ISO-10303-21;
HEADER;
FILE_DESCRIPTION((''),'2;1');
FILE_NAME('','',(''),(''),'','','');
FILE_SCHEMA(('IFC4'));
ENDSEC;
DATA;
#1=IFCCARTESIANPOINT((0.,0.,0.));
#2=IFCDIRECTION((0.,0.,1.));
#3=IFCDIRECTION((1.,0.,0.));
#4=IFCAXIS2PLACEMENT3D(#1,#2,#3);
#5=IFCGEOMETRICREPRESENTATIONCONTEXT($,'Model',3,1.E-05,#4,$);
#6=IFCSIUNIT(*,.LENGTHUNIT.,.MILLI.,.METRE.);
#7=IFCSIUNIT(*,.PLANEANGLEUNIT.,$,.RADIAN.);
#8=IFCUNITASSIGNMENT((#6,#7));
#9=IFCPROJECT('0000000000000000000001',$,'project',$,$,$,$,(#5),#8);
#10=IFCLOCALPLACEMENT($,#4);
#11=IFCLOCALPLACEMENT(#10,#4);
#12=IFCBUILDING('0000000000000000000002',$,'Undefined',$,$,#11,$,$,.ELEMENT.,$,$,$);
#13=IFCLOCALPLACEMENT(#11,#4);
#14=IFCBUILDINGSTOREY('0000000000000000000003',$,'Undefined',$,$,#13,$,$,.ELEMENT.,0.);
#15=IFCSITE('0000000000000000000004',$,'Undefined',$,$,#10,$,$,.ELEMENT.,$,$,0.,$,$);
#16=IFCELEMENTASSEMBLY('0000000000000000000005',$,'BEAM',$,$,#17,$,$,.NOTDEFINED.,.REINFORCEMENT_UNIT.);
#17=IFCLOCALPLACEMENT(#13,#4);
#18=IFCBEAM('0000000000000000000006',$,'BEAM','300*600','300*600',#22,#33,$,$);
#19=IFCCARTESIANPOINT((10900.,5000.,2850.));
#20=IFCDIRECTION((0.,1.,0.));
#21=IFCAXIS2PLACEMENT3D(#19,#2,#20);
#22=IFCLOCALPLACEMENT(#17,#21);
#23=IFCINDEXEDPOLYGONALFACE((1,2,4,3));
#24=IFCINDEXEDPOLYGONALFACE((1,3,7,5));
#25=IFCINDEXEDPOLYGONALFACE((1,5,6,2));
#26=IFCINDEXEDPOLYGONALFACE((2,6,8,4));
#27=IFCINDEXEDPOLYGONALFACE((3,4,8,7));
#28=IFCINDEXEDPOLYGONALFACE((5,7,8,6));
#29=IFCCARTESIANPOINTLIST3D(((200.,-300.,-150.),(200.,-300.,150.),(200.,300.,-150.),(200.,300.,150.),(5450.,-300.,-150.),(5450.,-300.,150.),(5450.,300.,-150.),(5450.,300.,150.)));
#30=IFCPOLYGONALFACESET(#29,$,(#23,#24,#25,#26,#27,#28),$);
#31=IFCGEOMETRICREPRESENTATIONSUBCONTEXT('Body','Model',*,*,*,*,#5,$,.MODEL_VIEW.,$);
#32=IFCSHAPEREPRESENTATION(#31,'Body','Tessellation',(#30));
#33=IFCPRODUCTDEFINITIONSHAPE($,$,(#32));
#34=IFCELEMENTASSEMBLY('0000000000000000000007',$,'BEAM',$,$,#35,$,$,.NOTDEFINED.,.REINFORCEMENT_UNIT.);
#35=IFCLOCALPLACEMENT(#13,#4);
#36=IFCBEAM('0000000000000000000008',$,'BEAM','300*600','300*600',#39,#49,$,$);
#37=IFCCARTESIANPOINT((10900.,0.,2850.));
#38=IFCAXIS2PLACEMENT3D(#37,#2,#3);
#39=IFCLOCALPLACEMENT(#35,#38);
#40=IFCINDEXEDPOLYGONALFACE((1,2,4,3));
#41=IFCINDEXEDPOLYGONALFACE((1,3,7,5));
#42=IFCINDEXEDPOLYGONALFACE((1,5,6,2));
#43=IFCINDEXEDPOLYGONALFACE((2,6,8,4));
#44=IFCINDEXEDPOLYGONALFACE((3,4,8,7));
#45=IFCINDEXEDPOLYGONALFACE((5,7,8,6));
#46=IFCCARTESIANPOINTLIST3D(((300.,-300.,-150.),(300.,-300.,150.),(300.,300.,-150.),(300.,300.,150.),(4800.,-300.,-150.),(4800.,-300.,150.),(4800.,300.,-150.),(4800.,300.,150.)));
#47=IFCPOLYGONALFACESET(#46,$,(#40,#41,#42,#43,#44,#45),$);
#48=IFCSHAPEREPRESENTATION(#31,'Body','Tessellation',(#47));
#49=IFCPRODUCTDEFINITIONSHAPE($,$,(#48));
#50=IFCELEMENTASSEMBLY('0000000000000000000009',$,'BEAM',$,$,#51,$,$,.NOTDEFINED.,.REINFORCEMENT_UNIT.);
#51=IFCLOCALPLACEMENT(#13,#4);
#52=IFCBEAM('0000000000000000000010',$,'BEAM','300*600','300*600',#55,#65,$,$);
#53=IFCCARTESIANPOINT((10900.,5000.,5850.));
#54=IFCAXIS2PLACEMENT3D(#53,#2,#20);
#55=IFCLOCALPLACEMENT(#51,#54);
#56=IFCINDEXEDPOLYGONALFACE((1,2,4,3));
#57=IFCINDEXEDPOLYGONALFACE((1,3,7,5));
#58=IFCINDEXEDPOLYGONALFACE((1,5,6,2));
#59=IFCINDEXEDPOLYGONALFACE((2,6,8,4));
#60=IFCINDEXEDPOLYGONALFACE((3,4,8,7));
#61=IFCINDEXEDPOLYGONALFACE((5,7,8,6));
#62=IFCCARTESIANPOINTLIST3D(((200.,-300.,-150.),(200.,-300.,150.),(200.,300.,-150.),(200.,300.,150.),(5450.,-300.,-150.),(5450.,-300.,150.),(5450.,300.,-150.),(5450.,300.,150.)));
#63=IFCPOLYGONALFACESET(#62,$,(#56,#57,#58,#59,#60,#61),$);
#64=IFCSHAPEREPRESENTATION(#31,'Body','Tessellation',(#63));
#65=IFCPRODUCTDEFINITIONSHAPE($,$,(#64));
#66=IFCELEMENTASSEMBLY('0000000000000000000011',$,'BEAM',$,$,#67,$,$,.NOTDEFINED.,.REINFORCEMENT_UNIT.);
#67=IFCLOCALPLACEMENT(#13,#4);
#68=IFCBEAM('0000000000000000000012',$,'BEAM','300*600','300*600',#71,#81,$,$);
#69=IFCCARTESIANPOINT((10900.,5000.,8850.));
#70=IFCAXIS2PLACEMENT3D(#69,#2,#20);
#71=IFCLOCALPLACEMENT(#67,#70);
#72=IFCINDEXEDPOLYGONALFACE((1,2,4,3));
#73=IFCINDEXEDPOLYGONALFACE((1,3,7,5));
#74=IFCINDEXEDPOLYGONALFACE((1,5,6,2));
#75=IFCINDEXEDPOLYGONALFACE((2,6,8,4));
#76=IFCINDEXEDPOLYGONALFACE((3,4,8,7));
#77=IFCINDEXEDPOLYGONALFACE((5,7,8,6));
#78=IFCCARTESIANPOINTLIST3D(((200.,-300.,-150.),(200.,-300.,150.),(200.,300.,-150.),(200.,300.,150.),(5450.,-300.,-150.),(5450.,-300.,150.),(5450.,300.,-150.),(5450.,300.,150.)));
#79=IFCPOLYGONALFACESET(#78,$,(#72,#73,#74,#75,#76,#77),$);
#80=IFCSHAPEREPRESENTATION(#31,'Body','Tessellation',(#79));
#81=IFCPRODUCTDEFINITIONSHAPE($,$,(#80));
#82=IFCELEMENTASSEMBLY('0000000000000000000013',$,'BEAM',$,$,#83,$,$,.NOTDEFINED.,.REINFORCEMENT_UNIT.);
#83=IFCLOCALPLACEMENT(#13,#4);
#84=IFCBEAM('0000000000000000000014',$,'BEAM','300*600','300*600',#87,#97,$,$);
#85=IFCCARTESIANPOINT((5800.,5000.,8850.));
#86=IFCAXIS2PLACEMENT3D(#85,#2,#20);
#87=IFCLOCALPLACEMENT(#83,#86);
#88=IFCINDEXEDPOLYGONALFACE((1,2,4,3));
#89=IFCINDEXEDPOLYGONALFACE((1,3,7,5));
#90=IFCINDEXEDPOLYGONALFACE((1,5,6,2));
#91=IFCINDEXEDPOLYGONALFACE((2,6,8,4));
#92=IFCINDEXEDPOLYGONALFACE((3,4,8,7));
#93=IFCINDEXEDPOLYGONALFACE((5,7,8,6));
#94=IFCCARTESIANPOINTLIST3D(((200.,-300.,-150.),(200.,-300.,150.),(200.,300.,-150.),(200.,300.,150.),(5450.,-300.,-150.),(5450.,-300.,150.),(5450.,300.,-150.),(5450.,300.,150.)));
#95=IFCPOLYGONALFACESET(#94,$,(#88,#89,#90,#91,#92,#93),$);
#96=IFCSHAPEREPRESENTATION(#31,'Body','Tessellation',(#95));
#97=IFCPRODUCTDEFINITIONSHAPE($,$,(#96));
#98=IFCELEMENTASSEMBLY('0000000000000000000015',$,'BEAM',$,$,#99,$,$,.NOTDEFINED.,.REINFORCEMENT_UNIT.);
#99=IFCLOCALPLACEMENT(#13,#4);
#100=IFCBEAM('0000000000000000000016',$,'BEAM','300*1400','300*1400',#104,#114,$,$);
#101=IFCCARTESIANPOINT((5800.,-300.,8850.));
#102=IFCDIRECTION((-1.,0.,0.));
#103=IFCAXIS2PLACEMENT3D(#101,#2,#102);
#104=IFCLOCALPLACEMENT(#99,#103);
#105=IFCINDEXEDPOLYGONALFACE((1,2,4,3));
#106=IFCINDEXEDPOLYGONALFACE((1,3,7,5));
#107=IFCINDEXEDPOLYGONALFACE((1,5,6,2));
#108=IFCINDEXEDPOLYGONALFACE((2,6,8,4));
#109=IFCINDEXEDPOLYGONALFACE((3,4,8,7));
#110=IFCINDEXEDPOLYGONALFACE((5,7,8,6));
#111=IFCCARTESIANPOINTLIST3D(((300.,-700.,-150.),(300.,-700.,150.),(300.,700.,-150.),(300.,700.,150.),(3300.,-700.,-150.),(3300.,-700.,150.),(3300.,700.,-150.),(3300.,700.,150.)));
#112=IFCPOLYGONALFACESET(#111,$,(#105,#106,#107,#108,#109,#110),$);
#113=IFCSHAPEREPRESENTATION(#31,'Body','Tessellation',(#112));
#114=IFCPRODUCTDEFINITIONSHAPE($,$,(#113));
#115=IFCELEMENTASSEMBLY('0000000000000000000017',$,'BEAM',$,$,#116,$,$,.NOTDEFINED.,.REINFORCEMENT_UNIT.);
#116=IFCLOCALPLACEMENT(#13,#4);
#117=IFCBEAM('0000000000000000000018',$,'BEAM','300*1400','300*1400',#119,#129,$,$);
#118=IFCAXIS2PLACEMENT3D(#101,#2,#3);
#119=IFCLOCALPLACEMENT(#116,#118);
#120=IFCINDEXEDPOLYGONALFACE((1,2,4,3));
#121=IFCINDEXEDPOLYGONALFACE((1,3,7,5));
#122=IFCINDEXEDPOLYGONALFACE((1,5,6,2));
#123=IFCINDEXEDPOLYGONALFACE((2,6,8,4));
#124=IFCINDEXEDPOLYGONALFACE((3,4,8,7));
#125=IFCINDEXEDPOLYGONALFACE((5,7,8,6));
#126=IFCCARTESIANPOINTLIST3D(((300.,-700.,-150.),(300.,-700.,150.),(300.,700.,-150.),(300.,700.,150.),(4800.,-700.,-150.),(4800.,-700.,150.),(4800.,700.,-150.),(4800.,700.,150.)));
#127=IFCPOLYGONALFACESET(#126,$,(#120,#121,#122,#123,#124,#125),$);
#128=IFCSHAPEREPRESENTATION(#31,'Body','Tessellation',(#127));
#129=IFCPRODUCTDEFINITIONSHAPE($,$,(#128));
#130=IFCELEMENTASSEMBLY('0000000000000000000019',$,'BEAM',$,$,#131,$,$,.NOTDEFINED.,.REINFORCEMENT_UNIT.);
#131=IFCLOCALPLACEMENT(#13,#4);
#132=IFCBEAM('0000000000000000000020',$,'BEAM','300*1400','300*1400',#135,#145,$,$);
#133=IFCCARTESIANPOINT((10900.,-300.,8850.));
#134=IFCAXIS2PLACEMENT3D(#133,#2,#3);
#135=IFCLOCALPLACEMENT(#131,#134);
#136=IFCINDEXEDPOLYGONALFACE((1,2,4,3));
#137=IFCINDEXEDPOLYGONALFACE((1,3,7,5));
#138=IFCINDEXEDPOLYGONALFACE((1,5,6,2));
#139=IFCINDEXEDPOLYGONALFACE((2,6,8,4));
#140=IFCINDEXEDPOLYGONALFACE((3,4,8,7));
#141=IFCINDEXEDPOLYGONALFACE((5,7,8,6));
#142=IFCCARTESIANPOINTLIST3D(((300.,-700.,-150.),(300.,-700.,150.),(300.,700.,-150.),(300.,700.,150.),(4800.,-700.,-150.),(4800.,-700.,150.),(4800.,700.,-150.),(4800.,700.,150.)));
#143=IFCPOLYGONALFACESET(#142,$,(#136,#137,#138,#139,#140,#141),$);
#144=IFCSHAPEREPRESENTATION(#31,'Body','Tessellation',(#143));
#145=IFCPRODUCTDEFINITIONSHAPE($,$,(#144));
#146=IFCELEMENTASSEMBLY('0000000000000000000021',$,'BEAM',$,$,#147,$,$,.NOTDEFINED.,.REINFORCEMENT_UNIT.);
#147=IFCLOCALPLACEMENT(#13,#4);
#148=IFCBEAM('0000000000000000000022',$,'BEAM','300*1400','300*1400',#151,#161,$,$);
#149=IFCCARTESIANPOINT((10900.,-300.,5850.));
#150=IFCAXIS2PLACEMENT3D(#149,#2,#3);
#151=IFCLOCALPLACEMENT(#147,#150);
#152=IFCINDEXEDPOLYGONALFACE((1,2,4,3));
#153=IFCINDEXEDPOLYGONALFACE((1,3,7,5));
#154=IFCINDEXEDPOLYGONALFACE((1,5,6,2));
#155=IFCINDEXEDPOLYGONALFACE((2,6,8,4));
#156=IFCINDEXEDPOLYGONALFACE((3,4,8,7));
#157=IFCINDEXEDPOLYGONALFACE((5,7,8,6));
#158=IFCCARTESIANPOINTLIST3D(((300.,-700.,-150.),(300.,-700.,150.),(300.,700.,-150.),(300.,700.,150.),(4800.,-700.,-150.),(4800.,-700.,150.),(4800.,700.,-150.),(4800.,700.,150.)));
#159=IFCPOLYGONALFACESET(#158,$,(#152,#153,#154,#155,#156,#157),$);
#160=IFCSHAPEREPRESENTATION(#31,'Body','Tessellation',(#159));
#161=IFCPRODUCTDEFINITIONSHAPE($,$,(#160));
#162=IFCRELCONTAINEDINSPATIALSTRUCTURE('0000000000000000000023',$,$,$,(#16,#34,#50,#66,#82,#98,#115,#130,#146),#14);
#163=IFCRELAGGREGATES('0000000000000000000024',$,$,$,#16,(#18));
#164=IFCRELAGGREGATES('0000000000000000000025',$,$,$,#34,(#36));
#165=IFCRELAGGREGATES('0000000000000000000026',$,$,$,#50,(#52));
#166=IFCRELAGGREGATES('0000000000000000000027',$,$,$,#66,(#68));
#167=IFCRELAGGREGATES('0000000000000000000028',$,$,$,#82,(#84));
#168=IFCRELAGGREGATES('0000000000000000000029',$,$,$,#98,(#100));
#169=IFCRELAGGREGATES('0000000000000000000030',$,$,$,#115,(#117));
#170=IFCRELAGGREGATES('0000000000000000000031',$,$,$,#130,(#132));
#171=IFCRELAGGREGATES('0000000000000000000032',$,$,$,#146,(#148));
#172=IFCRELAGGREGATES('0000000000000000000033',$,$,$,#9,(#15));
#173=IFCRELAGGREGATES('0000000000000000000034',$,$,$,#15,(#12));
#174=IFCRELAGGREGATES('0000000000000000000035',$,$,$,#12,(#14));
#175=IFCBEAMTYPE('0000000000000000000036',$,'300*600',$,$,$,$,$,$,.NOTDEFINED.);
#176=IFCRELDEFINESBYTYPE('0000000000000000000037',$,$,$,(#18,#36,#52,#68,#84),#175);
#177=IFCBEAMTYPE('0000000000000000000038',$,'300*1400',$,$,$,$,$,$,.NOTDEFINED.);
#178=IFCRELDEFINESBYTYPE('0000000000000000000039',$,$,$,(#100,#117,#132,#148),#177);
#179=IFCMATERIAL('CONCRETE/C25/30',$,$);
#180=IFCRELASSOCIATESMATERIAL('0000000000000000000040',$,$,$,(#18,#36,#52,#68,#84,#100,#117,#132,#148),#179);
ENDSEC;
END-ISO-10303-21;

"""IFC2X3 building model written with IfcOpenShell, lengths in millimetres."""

from ifc_helpers import new_model, si_unit, frame, origin_with_axes, origin_2d_with_axis, place, context, subcontext, project, spatial, rectangle, extrude, material, type_object, element, aggregate, save


model = new_model("IFC2X3")

# Units and contexts
model_context = context("Model", 3, precision=1e-05, world=origin_with_axes())
body_context = subcontext(model_context, "Body", "Model", "MODEL_VIEW")
ifc_project = project(units=[si_unit("LENGTHUNIT", "METRE", prefix="MILLI"), si_unit("PLANEANGLEUNIT", "RADIAN")], contexts=[model_context])

# Site, building, storey
site_placement = place(None, origin_with_axes())
site = spatial("IfcSite", under=ifc_project, at=site_placement, Name="Undefined", CompositionType="ELEMENT", RefElevation=0.0)
building_placement = place(site_placement, origin_with_axes())
building = spatial("IfcBuilding", under=site, at=building_placement, Name="Undefined", CompositionType="ELEMENT")
storey_placement = place(building_placement, origin_with_axes())
storey = spatial("IfcBuildingStorey", under=building, at=storey_placement, Name="Undefined", CompositionType="ELEMENT", Elevation=0.0)

# Shared definitions
ifc_material = material(Name="CONCRETE/C25/30")

# Element assemblies, beams
beam_type_1 = type_object("IfcBeamType", Name="300*600", PredefinedType="NOTDEFINED")
assembly_1_placement = place(storey_placement, origin_with_axes())
assembly_1 = element("IfcElementAssembly", 1, at=assembly_1_placement, inside=storey, Name="BEAM", AssemblyPlace="NOTDEFINED", PredefinedType="REINFORCEMENT_UNIT")
beam_1_placement = place(assembly_1_placement, frame((10900.0, 5000.0, 2850.0), z_axis=(0.0, 0.0, 1.0), x_axis=(0.0, 1.0, 0.0)))
beam_1 = element("IfcBeam", 2, at=beam_1_placement, type_object=beam_type_1, material=ifc_material, Name="BEAM", Description="300*600", ObjectType="300*600", context=body_context, shape_type="SweptSolid", body=[
    extrude(rectangle(XDim=600.0, YDim=300.0, at=origin_2d_with_axis()), frame((5450.0, 0.0, 0.0), z_axis=(-1.0, 0.0, 0.0), x_axis=(0.0, -1.0, 0.0)), (0.0, 0.0, 1.0), 5250.0),
])
aggregate(assembly_1, [beam_1])
assembly_2_placement = place(storey_placement, origin_with_axes())
assembly_2 = element("IfcElementAssembly", 3, at=assembly_2_placement, inside=storey, Name="BEAM", AssemblyPlace="NOTDEFINED", PredefinedType="REINFORCEMENT_UNIT")
beam_2_placement = place(assembly_2_placement, frame((10900.0, 0.0, 2850.0), z_axis=(0.0, 0.0, 1.0), x_axis=(1.0, 0.0, 0.0)))
beam_2 = element("IfcBeam", 4, at=beam_2_placement, type_object=beam_type_1, material=ifc_material, Name="BEAM", Description="300*600", ObjectType="300*600", context=body_context, shape_type="SweptSolid", body=[
    extrude(rectangle(XDim=600.0, YDim=300.0, at=origin_2d_with_axis()), frame((4800.0, 0.0, 0.0), z_axis=(-1.0, 0.0, 0.0), x_axis=(0.0, -1.0, 0.0)), (0.0, 0.0, 1.0), 4500.0),
])
aggregate(assembly_2, [beam_2])
assembly_3_placement = place(storey_placement, origin_with_axes())
assembly_3 = element("IfcElementAssembly", 5, at=assembly_3_placement, inside=storey, Name="BEAM", AssemblyPlace="NOTDEFINED", PredefinedType="REINFORCEMENT_UNIT")
beam_3_placement = place(assembly_3_placement, frame((10900.0, 5000.0, 5850.0), z_axis=(0.0, 0.0, 1.0), x_axis=(0.0, 1.0, 0.0)))
beam_3 = element("IfcBeam", 6, at=beam_3_placement, type_object=beam_type_1, material=ifc_material, Name="BEAM", Description="300*600", ObjectType="300*600", context=body_context, shape_type="SweptSolid", body=[
    extrude(rectangle(XDim=600.0, YDim=300.0, at=origin_2d_with_axis()), frame((5450.0, 0.0, 0.0), z_axis=(-1.0, 0.0, 0.0), x_axis=(0.0, -1.0, 0.0)), (0.0, 0.0, 1.0), 5250.0),
])
aggregate(assembly_3, [beam_3])
assembly_4_placement = place(storey_placement, origin_with_axes())
assembly_4 = element("IfcElementAssembly", 7, at=assembly_4_placement, inside=storey, Name="BEAM", AssemblyPlace="NOTDEFINED", PredefinedType="REINFORCEMENT_UNIT")
beam_4_placement = place(assembly_4_placement, frame((10900.0, 5000.0, 8850.0), z_axis=(0.0, 0.0, 1.0), x_axis=(0.0, 1.0, 0.0)))
beam_4 = element("IfcBeam", 8, at=beam_4_placement, type_object=beam_type_1, material=ifc_material, Name="BEAM", Description="300*600", ObjectType="300*600", context=body_context, shape_type="SweptSolid", body=[
    extrude(rectangle(XDim=600.0, YDim=300.0, at=origin_2d_with_axis()), frame((5450.0, 0.0, 0.0), z_axis=(-1.0, 0.0, 0.0), x_axis=(0.0, -1.0, 0.0)), (0.0, 0.0, 1.0), 5250.0),
])
aggregate(assembly_4, [beam_4])
assembly_5_placement = place(storey_placement, origin_with_axes())
assembly_5 = element("IfcElementAssembly", 9, at=assembly_5_placement, inside=storey, Name="BEAM", AssemblyPlace="NOTDEFINED", PredefinedType="REINFORCEMENT_UNIT")
beam_5_placement = place(assembly_5_placement, frame((5800.0, 5000.0, 8850.0), z_axis=(0.0, 0.0, 1.0), x_axis=(0.0, 1.0, 0.0)))
beam_5 = element("IfcBeam", 10, at=beam_5_placement, type_object=beam_type_1, material=ifc_material, Name="BEAM", Description="300*600", ObjectType="300*600", context=body_context, shape_type="SweptSolid", body=[
    extrude(rectangle(XDim=600.0, YDim=300.0, at=origin_2d_with_axis()), frame((5450.0, 0.0, 0.0), z_axis=(-1.0, 0.0, 0.0), x_axis=(0.0, -1.0, 0.0)), (0.0, 0.0, 1.0), 5250.0),
])
aggregate(assembly_5, [beam_5])
assembly_6_placement = place(storey_placement, origin_with_axes())
assembly_6 = element("IfcElementAssembly", 11, at=assembly_6_placement, inside=storey, Name="BEAM", AssemblyPlace="NOTDEFINED", PredefinedType="REINFORCEMENT_UNIT")
beam_type_2 = type_object("IfcBeamType", Name="300*1400", PredefinedType="NOTDEFINED")
beam_6_placement = place(assembly_6_placement, frame((5800.0, -300.0, 8850.0), z_axis=(0.0, 0.0, 1.0), x_axis=(-1.0, 0.0, 0.0)))
beam_6 = element("IfcBeam", 12, at=beam_6_placement, type_object=beam_type_2, material=ifc_material, Name="BEAM", Description="300*1400", ObjectType="300*1400", context=body_context, shape_type="SweptSolid", body=[
    extrude(rectangle(XDim=1400.0, YDim=300.0, at=origin_2d_with_axis()), frame((3300.0, 0.0, 0.0), z_axis=(-1.0, 0.0, 0.0), x_axis=(0.0, -1.0, 0.0)), (0.0, 0.0, 1.0), 3000.0),
])
aggregate(assembly_6, [beam_6])
assembly_7_placement = place(storey_placement, origin_with_axes())
assembly_7 = element("IfcElementAssembly", 13, at=assembly_7_placement, inside=storey, Name="BEAM", AssemblyPlace="NOTDEFINED", PredefinedType="REINFORCEMENT_UNIT")
beam_7_placement = place(assembly_7_placement, frame((5800.0, -300.0, 8850.0), z_axis=(0.0, 0.0, 1.0), x_axis=(1.0, 0.0, 0.0)))
beam_7 = element("IfcBeam", 14, at=beam_7_placement, type_object=beam_type_2, material=ifc_material, Name="BEAM", Description="300*1400", ObjectType="300*1400", context=body_context, shape_type="SweptSolid", body=[
    extrude(rectangle(XDim=1400.0, YDim=300.0, at=origin_2d_with_axis()), frame((4800.0, 0.0, 0.0), z_axis=(-1.0, 0.0, 0.0), x_axis=(0.0, -1.0, 0.0)), (0.0, 0.0, 1.0), 4500.0),
])
aggregate(assembly_7, [beam_7])
assembly_8_placement = place(storey_placement, origin_with_axes())
assembly_8 = element("IfcElementAssembly", 15, at=assembly_8_placement, inside=storey, Name="BEAM", AssemblyPlace="NOTDEFINED", PredefinedType="REINFORCEMENT_UNIT")
beam_8_placement = place(assembly_8_placement, frame((10900.0, -300.0, 8850.0), z_axis=(0.0, 0.0, 1.0), x_axis=(1.0, 0.0, 0.0)))
beam_8 = element("IfcBeam", 16, at=beam_8_placement, type_object=beam_type_2, material=ifc_material, Name="BEAM", Description="300*1400", ObjectType="300*1400", context=body_context, shape_type="SweptSolid", body=[
    extrude(rectangle(XDim=1400.0, YDim=300.0, at=origin_2d_with_axis()), frame((4800.0, 0.0, 0.0), z_axis=(-1.0, 0.0, 0.0), x_axis=(0.0, -1.0, 0.0)), (0.0, 0.0, 1.0), 4500.0),
])
aggregate(assembly_8, [beam_8])
assembly_9_placement = place(storey_placement, origin_with_axes())
assembly_9 = element("IfcElementAssembly", 17, at=assembly_9_placement, inside=storey, Name="BEAM", AssemblyPlace="NOTDEFINED", PredefinedType="REINFORCEMENT_UNIT")
beam_9_placement = place(assembly_9_placement, frame((10900.0, -300.0, 5850.0), z_axis=(0.0, 0.0, 1.0), x_axis=(1.0, 0.0, 0.0)))
beam_9 = element("IfcBeam", 18, at=beam_9_placement, type_object=beam_type_2, material=ifc_material, Name="BEAM", Description="300*1400", ObjectType="300*1400", context=body_context, shape_type="SweptSolid", body=[
    extrude(rectangle(XDim=1400.0, YDim=300.0, at=origin_2d_with_axis()), frame((4800.0, 0.0, 0.0), z_axis=(-1.0, 0.0, 0.0), x_axis=(0.0, -1.0, 0.0)), (0.0, 0.0, 1.0), 4500.0),
])
aggregate(assembly_9, [beam_9])

save(model, "model.ifc")
